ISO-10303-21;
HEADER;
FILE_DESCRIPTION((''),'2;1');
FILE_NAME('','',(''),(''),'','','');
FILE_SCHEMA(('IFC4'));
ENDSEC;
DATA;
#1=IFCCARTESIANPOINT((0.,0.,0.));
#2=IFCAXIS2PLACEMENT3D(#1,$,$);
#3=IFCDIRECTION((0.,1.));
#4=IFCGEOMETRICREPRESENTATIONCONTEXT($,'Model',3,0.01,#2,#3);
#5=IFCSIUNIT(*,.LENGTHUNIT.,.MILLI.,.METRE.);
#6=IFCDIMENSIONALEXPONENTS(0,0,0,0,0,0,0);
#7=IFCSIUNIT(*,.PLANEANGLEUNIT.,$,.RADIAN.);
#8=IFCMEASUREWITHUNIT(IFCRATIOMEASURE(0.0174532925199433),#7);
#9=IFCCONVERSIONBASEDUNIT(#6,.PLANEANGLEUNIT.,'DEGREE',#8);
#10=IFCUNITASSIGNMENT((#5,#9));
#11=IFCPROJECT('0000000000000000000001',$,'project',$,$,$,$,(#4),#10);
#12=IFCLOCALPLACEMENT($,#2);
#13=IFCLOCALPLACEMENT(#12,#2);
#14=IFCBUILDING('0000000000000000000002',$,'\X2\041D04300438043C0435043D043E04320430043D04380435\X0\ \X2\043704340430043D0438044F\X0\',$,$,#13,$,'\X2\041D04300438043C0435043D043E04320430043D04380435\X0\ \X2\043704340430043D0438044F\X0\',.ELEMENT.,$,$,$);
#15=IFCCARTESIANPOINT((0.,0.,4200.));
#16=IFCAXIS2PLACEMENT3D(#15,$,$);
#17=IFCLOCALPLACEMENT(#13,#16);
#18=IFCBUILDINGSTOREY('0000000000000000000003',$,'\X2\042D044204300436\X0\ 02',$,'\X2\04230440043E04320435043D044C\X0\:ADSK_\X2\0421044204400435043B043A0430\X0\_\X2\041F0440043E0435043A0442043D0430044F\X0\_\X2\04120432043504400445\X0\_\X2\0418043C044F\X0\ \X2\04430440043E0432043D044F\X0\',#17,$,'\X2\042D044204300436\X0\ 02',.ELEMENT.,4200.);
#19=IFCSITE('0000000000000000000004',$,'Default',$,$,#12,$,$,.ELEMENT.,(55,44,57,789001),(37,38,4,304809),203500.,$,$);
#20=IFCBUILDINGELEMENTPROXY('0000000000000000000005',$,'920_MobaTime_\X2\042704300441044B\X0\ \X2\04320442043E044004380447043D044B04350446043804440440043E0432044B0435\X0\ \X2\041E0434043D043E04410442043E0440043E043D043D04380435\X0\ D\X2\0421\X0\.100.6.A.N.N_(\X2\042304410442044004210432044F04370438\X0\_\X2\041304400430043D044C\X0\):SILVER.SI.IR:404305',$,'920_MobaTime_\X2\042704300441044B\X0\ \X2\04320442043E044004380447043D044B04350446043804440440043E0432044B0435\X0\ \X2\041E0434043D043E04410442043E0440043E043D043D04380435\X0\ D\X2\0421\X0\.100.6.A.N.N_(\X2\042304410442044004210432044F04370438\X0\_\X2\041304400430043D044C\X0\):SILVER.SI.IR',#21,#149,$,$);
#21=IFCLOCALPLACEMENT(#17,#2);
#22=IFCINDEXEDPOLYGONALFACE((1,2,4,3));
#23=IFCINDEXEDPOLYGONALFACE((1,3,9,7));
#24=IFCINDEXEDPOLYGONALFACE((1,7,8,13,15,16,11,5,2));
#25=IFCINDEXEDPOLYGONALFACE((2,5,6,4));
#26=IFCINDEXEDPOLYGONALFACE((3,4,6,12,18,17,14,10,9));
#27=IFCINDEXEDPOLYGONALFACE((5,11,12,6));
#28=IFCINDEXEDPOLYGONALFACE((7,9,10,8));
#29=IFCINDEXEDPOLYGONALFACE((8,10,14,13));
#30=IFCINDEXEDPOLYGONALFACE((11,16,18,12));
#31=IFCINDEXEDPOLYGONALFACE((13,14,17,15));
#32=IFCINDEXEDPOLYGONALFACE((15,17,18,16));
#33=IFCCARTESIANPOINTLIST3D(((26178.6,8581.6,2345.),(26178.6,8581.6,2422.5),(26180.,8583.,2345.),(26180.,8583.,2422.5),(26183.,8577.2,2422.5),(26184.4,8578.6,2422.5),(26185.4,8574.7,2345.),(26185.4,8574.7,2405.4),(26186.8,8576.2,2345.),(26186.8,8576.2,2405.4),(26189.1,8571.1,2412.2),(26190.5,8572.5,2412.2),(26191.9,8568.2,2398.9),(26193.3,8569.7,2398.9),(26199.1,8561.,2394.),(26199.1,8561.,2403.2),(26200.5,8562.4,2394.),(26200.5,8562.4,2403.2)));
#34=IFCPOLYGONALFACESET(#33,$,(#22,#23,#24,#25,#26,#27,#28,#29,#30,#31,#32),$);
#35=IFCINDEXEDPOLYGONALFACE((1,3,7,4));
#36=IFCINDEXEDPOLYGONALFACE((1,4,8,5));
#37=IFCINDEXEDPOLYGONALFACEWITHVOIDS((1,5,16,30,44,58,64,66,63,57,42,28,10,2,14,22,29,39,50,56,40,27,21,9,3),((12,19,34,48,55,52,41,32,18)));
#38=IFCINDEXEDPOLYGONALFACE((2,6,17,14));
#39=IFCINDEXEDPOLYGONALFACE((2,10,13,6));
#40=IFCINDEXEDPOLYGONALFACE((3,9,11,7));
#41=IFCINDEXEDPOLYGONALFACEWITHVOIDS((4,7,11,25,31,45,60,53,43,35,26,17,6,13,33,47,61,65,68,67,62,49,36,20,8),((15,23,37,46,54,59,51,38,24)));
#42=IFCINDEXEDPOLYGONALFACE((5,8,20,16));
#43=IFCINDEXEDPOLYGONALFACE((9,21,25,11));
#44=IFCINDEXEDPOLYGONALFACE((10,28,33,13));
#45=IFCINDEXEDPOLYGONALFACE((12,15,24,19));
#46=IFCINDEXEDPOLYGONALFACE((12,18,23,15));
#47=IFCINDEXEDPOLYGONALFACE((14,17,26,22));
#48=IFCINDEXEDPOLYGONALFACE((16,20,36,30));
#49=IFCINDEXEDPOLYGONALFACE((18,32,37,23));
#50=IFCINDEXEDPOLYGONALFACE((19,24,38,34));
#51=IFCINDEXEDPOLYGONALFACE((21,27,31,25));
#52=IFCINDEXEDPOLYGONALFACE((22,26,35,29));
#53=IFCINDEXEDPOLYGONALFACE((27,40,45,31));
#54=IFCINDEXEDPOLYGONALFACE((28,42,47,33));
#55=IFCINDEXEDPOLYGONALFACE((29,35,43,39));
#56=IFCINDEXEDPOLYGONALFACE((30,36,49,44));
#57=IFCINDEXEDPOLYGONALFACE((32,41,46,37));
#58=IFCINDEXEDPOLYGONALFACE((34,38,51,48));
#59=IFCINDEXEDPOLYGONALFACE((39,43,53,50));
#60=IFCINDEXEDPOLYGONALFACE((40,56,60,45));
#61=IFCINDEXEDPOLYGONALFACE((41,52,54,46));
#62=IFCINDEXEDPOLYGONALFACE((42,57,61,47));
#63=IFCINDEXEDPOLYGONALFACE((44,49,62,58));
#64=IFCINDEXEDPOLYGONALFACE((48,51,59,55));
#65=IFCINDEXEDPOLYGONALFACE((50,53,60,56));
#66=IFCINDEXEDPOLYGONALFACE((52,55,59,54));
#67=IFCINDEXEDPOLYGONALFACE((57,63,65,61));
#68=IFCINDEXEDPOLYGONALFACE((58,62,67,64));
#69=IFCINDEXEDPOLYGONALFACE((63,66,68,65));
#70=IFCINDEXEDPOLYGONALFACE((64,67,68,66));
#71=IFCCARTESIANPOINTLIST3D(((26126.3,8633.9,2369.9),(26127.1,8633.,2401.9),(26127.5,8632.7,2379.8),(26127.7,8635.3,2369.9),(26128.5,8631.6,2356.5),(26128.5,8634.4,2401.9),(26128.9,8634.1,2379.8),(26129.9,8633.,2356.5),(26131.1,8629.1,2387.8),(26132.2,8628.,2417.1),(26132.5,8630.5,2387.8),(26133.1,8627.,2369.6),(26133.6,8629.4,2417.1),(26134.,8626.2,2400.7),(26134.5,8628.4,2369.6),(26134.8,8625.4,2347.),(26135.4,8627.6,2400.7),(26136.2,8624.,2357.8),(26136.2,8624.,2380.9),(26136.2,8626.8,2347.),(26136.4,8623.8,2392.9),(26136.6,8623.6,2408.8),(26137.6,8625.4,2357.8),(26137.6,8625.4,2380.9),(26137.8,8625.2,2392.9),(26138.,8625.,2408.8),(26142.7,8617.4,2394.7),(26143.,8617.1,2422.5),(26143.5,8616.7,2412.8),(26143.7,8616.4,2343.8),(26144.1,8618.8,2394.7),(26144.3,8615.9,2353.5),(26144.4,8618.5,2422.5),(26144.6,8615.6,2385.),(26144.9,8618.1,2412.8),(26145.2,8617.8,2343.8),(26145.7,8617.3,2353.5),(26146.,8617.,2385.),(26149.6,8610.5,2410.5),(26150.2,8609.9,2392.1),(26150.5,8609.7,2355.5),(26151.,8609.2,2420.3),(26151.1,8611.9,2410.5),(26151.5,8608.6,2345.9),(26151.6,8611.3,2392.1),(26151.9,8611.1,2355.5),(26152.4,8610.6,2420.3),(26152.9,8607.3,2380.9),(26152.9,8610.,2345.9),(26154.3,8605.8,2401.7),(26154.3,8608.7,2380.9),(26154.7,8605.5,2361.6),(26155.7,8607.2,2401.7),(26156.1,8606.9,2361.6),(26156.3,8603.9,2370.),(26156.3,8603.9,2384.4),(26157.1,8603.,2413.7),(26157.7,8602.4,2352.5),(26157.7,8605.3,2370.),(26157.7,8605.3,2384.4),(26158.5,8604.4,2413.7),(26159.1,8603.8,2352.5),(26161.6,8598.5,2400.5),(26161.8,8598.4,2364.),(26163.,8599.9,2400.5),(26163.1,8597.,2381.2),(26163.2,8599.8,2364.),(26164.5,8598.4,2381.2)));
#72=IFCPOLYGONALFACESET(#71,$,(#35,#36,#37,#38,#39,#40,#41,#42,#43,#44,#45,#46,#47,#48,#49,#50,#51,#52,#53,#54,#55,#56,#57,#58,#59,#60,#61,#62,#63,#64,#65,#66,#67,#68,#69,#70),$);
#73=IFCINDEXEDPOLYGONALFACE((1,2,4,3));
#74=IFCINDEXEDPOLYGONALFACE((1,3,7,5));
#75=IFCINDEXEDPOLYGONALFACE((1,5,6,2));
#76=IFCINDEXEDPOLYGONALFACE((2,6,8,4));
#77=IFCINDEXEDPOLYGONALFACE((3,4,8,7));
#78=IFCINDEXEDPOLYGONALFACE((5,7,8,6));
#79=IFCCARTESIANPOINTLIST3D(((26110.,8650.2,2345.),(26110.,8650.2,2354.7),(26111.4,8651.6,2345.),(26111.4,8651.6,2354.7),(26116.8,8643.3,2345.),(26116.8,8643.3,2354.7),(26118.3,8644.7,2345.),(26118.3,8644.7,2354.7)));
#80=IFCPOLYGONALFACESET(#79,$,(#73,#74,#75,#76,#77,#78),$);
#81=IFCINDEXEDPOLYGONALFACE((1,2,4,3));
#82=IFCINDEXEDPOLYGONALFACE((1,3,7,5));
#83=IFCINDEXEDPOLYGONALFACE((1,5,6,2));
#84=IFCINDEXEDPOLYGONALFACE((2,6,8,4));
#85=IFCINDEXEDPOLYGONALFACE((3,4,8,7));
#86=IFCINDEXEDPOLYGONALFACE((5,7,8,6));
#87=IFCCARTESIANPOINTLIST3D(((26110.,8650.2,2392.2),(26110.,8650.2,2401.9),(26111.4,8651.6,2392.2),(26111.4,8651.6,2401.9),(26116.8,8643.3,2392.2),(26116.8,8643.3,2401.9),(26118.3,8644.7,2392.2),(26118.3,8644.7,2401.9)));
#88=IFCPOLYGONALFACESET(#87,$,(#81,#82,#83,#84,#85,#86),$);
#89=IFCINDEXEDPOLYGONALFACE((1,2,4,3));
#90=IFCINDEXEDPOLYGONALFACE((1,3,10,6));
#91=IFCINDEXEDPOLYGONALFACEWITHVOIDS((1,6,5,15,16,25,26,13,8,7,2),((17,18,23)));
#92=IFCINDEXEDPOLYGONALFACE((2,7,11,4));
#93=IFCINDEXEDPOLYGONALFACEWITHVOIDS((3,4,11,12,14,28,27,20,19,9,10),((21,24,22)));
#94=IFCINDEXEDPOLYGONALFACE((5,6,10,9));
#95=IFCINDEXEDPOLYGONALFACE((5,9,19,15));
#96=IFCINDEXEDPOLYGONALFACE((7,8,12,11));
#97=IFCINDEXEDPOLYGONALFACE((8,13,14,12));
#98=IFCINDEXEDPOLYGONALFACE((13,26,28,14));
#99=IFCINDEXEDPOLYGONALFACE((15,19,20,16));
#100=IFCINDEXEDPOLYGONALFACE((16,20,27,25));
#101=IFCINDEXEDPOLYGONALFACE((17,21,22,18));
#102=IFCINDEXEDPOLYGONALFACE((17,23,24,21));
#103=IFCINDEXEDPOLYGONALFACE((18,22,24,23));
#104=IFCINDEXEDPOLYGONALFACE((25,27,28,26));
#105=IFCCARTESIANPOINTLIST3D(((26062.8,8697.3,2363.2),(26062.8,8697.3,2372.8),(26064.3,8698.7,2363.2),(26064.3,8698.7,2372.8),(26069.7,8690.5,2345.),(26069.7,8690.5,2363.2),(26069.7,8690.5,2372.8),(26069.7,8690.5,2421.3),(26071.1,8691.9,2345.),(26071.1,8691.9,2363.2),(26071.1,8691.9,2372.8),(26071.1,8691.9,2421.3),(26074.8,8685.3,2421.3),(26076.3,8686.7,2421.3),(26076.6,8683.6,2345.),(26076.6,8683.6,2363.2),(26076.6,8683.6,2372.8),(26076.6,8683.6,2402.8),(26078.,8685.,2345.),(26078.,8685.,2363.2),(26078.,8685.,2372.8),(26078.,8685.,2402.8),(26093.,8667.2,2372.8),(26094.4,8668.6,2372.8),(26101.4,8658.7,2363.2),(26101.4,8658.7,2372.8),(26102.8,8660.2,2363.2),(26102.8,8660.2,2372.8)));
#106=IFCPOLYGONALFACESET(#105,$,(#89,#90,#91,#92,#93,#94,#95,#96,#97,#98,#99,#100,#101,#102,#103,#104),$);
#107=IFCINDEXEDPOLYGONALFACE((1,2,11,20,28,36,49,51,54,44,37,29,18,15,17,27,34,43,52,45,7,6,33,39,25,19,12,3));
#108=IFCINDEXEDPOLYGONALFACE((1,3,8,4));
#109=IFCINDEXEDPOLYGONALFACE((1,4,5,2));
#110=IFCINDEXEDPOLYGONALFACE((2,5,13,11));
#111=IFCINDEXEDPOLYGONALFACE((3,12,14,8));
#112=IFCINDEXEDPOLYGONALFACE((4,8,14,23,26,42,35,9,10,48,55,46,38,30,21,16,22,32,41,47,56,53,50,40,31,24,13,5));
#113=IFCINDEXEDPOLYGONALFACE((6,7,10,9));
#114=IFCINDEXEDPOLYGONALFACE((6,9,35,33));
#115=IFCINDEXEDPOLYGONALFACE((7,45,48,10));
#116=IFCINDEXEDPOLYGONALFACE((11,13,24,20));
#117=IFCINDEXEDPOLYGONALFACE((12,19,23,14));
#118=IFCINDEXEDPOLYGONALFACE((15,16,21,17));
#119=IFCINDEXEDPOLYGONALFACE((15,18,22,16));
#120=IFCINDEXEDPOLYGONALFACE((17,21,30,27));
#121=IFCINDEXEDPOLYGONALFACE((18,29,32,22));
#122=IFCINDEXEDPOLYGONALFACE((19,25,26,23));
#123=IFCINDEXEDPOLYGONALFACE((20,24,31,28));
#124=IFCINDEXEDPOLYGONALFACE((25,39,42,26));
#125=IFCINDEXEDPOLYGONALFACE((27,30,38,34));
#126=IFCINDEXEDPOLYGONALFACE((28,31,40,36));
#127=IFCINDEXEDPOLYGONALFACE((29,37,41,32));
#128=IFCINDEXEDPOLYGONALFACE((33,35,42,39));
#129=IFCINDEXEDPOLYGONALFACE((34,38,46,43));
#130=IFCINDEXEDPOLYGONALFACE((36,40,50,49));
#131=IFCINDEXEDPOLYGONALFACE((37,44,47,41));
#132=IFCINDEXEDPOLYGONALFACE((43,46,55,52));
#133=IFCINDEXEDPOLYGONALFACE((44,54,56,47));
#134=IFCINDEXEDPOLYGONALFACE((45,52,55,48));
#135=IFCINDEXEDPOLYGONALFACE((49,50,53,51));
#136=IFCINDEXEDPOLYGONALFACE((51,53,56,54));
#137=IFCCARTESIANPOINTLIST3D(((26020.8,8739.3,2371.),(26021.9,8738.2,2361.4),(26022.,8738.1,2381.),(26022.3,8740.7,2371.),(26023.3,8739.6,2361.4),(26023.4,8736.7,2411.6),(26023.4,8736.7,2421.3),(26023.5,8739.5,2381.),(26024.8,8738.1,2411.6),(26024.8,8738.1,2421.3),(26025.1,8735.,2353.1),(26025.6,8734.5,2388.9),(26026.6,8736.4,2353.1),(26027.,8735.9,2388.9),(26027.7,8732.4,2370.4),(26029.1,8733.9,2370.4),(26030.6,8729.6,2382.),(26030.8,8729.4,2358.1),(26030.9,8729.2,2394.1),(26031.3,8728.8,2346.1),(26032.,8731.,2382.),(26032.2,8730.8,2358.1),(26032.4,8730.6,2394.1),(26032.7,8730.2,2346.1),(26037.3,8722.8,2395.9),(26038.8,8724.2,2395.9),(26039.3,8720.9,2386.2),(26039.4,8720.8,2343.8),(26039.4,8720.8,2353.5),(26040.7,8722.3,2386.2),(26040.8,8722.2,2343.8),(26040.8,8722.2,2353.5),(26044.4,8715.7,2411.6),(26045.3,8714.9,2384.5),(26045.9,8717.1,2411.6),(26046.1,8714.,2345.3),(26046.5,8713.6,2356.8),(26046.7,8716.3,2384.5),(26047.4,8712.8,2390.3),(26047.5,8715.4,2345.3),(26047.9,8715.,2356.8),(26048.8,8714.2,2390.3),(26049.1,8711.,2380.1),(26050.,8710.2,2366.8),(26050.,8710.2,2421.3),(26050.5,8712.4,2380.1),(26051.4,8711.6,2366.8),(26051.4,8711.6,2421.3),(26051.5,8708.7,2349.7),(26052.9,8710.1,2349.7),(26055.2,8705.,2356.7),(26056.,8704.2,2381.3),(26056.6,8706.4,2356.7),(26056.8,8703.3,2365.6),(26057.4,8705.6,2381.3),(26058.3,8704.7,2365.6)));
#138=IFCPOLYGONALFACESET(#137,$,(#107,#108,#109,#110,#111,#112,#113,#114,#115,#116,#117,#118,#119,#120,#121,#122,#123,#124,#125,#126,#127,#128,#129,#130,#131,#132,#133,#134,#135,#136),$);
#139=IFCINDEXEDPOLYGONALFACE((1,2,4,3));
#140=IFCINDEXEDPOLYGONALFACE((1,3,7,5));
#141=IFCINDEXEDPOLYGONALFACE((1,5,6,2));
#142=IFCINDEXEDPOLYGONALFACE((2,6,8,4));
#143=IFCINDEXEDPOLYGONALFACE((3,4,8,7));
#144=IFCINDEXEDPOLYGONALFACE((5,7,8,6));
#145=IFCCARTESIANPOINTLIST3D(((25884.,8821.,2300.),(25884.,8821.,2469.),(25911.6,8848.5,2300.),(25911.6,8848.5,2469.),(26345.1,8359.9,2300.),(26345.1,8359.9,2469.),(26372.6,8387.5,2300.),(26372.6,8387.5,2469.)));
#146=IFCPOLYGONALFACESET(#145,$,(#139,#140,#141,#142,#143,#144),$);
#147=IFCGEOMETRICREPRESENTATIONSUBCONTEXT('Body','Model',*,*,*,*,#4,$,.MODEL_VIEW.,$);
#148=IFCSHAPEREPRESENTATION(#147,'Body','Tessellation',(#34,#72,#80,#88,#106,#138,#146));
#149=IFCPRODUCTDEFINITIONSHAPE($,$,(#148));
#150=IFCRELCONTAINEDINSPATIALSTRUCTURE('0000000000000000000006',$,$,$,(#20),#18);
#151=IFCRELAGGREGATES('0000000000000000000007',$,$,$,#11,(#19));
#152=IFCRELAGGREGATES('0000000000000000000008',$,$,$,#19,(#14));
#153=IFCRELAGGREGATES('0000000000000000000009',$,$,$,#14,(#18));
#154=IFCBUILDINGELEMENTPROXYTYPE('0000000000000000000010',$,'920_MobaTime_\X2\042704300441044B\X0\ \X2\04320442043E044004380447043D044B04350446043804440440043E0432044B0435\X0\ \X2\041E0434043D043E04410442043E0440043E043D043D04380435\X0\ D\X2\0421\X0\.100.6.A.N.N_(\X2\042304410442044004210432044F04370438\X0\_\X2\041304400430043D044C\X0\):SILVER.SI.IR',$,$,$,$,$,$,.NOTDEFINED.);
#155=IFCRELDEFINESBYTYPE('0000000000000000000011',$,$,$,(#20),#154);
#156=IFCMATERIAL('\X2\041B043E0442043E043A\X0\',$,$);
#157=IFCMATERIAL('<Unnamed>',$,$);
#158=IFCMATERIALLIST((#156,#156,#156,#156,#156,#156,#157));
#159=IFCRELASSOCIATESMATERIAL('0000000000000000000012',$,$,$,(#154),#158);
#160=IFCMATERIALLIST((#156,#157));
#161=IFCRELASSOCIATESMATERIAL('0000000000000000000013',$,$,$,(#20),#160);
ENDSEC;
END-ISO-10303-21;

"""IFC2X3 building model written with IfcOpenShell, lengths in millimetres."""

from ifc_helpers import new_model, entity, si_unit, converted_unit, direction, frame, origin, origin_2d_with_axis, place, context, subcontext, project, spatial, polyline, rectangle, outline, extrude, source, transform, mapped, material, material_list, type_object, type_shapes, element, save


model = new_model("IFC2X3")

# Units and contexts
model_context = context("Model", 3, precision=0.01, world=origin(), true_north=direction((0.0, 1.0)))
body_context = subcontext(model_context, "Body", "Model", "MODEL_VIEW")
ifc_project = project(units=[si_unit("LENGTHUNIT", "METRE", prefix="MILLI"), converted_unit("PLANEANGLEUNIT", "DEGREE", entity("IfcRatioMeasure", 0.0174532925199433), si_unit("PLANEANGLEUNIT", "RADIAN"), dimensions=[0, 0, 0, 0, 0, 0, 0])], contexts=[model_context])

# Site, building, storey
site_placement = place(None, frame((0.0, 0.0, 0.0)))
site = spatial("IfcSite", under=ifc_project, at=site_placement, Name="Default", CompositionType="ELEMENT", RefLatitude=(55, 44, 57, 789001), RefLongitude=(37, 38, 4, 304809), RefElevation=203500.0)
building_placement = place(site_placement, origin())
building = spatial("IfcBuilding", under=site, at=building_placement, Name="Наименование здания", LongName="Наименование здания", CompositionType="ELEMENT")
storey_placement = place(building_placement, frame((0.0, 0.0, 4200.0)))
storey = spatial("IfcBuildingStorey", under=building, at=storey_placement, Name="Этаж 02", ObjectType="Уровень:ADSK_Стрелка_Проектная_Вверх_Имя уровня", LongName="Этаж 02", CompositionType="ELEMENT", Elevation=4200.0)

# Building element proxy
ifc_material_1 = material(Name="Лоток")
ifc_material_2 = material(Name="<Unnamed>")
ifc_material_list_1 = material_list([ifc_material_1, ifc_material_1, ifc_material_1, ifc_material_1, ifc_material_1, ifc_material_1, ifc_material_2])
building_element_proxy_type_1 = type_object("IfcBuildingElementProxyType", Name="920_MobaTime_Часы вторичныецифровые Односторонние DС.100.6.A.N.N_(УстрСвязи_Грань):SILVER.SI.IR", PredefinedType="NOTDEFINED", material=ifc_material_list_1)
shared_shape_1 = source(origin(), body_context, "Body", "SweptSolid", [
    extrude(outline(polyline([(-49.3, -13.1), (28.2, -13.1), (28.2, -6.8), (17.9, 1.8), (8.9, 16.0), (-0.3, 16.0), (4.6, 5.8), (11.1, -3.4), (-49.3, -3.4), (-49.3, -13.1)])), frame((-64.6, 9.8, 39.0), z_axis=(0.0, 0.0, 1.0), x_axis=(0.0, 1.0, 0.0)), (0.0, 0.0, 1.0), 2.0),
    extrude(outline(polyline([(2.2, -27.6), (19.0, -27.6), (30.5, -16.1), (33.3, -4.9), (31.0, 5.8), (21.8, 17.2), (5.2, 27.3), (-11.1, 33.0), (-24.0, 32.7), (-33.6, 27.6), (-40.3, 18.6), (-42.8, 5.7), (-38.0, -6.3), (-27.2, -15.0), (-17.5, -17.7), (-8.2, -16.4), (-0.3, -11.9), (5.1, -4.5), (7.3, 6.2), (4.0, 17.2), (18.5, 7.3), (23.6, -2.4), (22.0, -11.4), (14.2, -18.4), (5.3, -18.3), (2.2, -27.6)]), holes=[polyline([(-9.0, 23.3), (-1.3, 14.4), (-2.6, 2.0), (-11.4, -7.0), (-23.4, -6.1), (-32.2, 2.9), (-31.2, 15.1), (-25.6, 22.1), (-17.5, 24.9), (-9.0, 23.3)])]), frame((-2.7, 3.6, 39.0), z_axis=(0.0, 0.0, 1.0), x_axis=(-0.427649, 0.903945, 0.0)), (0.0, 0.0, 1.0), 2.0),
    extrude(rectangle(XDim=9.7, YDim=9.7, at=origin_2d_with_axis()), frame((40.6, -34.7, 39.0)), (0.0, 0.0, 1.0), 2.0),
    extrude(rectangle(XDim=9.7, YDim=9.7, at=origin_2d_with_axis()), frame((40.6, 12.6, 39.0)), (0.0, 0.0, 1.0), 2.0),
    extrude(outline(polyline([(-0.9, -28.1), (8.8, -28.1), (8.8, -9.9), (18.5, -9.9), (18.5, -0.2), (8.8, -0.2), (8.8, 48.3), (1.5, 48.3), (-36.0, -0.2), (-36.0, -9.9), (-0.9, -9.9), (-0.9, -28.1)]), holes=[polyline([(-0.9, -0.2), (-24.1, -0.2), (-0.9, 29.7), (-0.9, -0.2)])]), frame((93.6, -11.4, 39.0)), (0.0, 0.0, 1.0), 2.0),
    extrude(outline(polyline([(3.3, -28.3), (12.5, -28.3), (20.5, -25.0), (26.8, -18.8), (30.7, -10.0), (31.4, 1.6), (26.9, 11.8), (20.1, 18.4), (11.1, 22.3), (1.0, 23.3), (-7.9, 20.4), (-14.9, 14.5), (-18.9, 6.2), (-17.1, -9.0), (-36.7, 0.5), (-29.1, 29.3), (-38.5, 31.7), (-48.1, -4.6), (-11.6, -23.0), (-8.0, -14.0), (-10.8, -7.6), (-10.2, 1.1), (-3.0, 11.8), (9.2, 12.8), (20.0, 5.4), (21.3, -7.5), (15.5, -16.4), (4.6, -18.6), (3.3, -28.3)])), frame((147.1, -8.5, 39.0), z_axis=(0.0, 0.0, 1.0), x_axis=(0.256974, -0.966418, 0.0)), (0.0, 0.0, 1.0), 2.0),
    extrude(rectangle(XDim=652.0, YDim=169.0, at=origin_2d_with_axis()), frame((0.0, 0.0, 0.0), z_axis=(0.0, 0.0, 1.0), x_axis=(-1.0, 0.0, 0.0)), (0.0, 0.0, 1.0), 39.0),
])
type_shapes(building_element_proxy_type_1, [shared_shape_1])
ifc_material_list_2 = material_list([ifc_material_1, ifc_material_2])
proxy_1_placement = place(storey_placement, frame((26114.6, 8590.4, 2384.5), z_axis=(0.707107, 0.707107, 0.0), x_axis=(-0.707107, 0.707107, 0.0)))
element("IfcBuildingElementProxy", 1, at=proxy_1_placement, inside=storey, type_object=building_element_proxy_type_1, material=ifc_material_list_2, Name="920_MobaTime_Часы вторичныецифровые Односторонние DС.100.6.A.N.N_(УстрСвязи_Грань):SILVER.SI.IR:404305", ObjectType="920_MobaTime_Часы вторичныецифровые Односторонние DС.100.6.A.N.N_(УстрСвязи_Грань):SILVER.SI.IR", context=body_context, shape_type="MappedRepresentation", body=[
    mapped(shared_shape_1, transform((0.0, 0.0, 0.0), scale=1.0)),
])

save(model, "model.ifc")
